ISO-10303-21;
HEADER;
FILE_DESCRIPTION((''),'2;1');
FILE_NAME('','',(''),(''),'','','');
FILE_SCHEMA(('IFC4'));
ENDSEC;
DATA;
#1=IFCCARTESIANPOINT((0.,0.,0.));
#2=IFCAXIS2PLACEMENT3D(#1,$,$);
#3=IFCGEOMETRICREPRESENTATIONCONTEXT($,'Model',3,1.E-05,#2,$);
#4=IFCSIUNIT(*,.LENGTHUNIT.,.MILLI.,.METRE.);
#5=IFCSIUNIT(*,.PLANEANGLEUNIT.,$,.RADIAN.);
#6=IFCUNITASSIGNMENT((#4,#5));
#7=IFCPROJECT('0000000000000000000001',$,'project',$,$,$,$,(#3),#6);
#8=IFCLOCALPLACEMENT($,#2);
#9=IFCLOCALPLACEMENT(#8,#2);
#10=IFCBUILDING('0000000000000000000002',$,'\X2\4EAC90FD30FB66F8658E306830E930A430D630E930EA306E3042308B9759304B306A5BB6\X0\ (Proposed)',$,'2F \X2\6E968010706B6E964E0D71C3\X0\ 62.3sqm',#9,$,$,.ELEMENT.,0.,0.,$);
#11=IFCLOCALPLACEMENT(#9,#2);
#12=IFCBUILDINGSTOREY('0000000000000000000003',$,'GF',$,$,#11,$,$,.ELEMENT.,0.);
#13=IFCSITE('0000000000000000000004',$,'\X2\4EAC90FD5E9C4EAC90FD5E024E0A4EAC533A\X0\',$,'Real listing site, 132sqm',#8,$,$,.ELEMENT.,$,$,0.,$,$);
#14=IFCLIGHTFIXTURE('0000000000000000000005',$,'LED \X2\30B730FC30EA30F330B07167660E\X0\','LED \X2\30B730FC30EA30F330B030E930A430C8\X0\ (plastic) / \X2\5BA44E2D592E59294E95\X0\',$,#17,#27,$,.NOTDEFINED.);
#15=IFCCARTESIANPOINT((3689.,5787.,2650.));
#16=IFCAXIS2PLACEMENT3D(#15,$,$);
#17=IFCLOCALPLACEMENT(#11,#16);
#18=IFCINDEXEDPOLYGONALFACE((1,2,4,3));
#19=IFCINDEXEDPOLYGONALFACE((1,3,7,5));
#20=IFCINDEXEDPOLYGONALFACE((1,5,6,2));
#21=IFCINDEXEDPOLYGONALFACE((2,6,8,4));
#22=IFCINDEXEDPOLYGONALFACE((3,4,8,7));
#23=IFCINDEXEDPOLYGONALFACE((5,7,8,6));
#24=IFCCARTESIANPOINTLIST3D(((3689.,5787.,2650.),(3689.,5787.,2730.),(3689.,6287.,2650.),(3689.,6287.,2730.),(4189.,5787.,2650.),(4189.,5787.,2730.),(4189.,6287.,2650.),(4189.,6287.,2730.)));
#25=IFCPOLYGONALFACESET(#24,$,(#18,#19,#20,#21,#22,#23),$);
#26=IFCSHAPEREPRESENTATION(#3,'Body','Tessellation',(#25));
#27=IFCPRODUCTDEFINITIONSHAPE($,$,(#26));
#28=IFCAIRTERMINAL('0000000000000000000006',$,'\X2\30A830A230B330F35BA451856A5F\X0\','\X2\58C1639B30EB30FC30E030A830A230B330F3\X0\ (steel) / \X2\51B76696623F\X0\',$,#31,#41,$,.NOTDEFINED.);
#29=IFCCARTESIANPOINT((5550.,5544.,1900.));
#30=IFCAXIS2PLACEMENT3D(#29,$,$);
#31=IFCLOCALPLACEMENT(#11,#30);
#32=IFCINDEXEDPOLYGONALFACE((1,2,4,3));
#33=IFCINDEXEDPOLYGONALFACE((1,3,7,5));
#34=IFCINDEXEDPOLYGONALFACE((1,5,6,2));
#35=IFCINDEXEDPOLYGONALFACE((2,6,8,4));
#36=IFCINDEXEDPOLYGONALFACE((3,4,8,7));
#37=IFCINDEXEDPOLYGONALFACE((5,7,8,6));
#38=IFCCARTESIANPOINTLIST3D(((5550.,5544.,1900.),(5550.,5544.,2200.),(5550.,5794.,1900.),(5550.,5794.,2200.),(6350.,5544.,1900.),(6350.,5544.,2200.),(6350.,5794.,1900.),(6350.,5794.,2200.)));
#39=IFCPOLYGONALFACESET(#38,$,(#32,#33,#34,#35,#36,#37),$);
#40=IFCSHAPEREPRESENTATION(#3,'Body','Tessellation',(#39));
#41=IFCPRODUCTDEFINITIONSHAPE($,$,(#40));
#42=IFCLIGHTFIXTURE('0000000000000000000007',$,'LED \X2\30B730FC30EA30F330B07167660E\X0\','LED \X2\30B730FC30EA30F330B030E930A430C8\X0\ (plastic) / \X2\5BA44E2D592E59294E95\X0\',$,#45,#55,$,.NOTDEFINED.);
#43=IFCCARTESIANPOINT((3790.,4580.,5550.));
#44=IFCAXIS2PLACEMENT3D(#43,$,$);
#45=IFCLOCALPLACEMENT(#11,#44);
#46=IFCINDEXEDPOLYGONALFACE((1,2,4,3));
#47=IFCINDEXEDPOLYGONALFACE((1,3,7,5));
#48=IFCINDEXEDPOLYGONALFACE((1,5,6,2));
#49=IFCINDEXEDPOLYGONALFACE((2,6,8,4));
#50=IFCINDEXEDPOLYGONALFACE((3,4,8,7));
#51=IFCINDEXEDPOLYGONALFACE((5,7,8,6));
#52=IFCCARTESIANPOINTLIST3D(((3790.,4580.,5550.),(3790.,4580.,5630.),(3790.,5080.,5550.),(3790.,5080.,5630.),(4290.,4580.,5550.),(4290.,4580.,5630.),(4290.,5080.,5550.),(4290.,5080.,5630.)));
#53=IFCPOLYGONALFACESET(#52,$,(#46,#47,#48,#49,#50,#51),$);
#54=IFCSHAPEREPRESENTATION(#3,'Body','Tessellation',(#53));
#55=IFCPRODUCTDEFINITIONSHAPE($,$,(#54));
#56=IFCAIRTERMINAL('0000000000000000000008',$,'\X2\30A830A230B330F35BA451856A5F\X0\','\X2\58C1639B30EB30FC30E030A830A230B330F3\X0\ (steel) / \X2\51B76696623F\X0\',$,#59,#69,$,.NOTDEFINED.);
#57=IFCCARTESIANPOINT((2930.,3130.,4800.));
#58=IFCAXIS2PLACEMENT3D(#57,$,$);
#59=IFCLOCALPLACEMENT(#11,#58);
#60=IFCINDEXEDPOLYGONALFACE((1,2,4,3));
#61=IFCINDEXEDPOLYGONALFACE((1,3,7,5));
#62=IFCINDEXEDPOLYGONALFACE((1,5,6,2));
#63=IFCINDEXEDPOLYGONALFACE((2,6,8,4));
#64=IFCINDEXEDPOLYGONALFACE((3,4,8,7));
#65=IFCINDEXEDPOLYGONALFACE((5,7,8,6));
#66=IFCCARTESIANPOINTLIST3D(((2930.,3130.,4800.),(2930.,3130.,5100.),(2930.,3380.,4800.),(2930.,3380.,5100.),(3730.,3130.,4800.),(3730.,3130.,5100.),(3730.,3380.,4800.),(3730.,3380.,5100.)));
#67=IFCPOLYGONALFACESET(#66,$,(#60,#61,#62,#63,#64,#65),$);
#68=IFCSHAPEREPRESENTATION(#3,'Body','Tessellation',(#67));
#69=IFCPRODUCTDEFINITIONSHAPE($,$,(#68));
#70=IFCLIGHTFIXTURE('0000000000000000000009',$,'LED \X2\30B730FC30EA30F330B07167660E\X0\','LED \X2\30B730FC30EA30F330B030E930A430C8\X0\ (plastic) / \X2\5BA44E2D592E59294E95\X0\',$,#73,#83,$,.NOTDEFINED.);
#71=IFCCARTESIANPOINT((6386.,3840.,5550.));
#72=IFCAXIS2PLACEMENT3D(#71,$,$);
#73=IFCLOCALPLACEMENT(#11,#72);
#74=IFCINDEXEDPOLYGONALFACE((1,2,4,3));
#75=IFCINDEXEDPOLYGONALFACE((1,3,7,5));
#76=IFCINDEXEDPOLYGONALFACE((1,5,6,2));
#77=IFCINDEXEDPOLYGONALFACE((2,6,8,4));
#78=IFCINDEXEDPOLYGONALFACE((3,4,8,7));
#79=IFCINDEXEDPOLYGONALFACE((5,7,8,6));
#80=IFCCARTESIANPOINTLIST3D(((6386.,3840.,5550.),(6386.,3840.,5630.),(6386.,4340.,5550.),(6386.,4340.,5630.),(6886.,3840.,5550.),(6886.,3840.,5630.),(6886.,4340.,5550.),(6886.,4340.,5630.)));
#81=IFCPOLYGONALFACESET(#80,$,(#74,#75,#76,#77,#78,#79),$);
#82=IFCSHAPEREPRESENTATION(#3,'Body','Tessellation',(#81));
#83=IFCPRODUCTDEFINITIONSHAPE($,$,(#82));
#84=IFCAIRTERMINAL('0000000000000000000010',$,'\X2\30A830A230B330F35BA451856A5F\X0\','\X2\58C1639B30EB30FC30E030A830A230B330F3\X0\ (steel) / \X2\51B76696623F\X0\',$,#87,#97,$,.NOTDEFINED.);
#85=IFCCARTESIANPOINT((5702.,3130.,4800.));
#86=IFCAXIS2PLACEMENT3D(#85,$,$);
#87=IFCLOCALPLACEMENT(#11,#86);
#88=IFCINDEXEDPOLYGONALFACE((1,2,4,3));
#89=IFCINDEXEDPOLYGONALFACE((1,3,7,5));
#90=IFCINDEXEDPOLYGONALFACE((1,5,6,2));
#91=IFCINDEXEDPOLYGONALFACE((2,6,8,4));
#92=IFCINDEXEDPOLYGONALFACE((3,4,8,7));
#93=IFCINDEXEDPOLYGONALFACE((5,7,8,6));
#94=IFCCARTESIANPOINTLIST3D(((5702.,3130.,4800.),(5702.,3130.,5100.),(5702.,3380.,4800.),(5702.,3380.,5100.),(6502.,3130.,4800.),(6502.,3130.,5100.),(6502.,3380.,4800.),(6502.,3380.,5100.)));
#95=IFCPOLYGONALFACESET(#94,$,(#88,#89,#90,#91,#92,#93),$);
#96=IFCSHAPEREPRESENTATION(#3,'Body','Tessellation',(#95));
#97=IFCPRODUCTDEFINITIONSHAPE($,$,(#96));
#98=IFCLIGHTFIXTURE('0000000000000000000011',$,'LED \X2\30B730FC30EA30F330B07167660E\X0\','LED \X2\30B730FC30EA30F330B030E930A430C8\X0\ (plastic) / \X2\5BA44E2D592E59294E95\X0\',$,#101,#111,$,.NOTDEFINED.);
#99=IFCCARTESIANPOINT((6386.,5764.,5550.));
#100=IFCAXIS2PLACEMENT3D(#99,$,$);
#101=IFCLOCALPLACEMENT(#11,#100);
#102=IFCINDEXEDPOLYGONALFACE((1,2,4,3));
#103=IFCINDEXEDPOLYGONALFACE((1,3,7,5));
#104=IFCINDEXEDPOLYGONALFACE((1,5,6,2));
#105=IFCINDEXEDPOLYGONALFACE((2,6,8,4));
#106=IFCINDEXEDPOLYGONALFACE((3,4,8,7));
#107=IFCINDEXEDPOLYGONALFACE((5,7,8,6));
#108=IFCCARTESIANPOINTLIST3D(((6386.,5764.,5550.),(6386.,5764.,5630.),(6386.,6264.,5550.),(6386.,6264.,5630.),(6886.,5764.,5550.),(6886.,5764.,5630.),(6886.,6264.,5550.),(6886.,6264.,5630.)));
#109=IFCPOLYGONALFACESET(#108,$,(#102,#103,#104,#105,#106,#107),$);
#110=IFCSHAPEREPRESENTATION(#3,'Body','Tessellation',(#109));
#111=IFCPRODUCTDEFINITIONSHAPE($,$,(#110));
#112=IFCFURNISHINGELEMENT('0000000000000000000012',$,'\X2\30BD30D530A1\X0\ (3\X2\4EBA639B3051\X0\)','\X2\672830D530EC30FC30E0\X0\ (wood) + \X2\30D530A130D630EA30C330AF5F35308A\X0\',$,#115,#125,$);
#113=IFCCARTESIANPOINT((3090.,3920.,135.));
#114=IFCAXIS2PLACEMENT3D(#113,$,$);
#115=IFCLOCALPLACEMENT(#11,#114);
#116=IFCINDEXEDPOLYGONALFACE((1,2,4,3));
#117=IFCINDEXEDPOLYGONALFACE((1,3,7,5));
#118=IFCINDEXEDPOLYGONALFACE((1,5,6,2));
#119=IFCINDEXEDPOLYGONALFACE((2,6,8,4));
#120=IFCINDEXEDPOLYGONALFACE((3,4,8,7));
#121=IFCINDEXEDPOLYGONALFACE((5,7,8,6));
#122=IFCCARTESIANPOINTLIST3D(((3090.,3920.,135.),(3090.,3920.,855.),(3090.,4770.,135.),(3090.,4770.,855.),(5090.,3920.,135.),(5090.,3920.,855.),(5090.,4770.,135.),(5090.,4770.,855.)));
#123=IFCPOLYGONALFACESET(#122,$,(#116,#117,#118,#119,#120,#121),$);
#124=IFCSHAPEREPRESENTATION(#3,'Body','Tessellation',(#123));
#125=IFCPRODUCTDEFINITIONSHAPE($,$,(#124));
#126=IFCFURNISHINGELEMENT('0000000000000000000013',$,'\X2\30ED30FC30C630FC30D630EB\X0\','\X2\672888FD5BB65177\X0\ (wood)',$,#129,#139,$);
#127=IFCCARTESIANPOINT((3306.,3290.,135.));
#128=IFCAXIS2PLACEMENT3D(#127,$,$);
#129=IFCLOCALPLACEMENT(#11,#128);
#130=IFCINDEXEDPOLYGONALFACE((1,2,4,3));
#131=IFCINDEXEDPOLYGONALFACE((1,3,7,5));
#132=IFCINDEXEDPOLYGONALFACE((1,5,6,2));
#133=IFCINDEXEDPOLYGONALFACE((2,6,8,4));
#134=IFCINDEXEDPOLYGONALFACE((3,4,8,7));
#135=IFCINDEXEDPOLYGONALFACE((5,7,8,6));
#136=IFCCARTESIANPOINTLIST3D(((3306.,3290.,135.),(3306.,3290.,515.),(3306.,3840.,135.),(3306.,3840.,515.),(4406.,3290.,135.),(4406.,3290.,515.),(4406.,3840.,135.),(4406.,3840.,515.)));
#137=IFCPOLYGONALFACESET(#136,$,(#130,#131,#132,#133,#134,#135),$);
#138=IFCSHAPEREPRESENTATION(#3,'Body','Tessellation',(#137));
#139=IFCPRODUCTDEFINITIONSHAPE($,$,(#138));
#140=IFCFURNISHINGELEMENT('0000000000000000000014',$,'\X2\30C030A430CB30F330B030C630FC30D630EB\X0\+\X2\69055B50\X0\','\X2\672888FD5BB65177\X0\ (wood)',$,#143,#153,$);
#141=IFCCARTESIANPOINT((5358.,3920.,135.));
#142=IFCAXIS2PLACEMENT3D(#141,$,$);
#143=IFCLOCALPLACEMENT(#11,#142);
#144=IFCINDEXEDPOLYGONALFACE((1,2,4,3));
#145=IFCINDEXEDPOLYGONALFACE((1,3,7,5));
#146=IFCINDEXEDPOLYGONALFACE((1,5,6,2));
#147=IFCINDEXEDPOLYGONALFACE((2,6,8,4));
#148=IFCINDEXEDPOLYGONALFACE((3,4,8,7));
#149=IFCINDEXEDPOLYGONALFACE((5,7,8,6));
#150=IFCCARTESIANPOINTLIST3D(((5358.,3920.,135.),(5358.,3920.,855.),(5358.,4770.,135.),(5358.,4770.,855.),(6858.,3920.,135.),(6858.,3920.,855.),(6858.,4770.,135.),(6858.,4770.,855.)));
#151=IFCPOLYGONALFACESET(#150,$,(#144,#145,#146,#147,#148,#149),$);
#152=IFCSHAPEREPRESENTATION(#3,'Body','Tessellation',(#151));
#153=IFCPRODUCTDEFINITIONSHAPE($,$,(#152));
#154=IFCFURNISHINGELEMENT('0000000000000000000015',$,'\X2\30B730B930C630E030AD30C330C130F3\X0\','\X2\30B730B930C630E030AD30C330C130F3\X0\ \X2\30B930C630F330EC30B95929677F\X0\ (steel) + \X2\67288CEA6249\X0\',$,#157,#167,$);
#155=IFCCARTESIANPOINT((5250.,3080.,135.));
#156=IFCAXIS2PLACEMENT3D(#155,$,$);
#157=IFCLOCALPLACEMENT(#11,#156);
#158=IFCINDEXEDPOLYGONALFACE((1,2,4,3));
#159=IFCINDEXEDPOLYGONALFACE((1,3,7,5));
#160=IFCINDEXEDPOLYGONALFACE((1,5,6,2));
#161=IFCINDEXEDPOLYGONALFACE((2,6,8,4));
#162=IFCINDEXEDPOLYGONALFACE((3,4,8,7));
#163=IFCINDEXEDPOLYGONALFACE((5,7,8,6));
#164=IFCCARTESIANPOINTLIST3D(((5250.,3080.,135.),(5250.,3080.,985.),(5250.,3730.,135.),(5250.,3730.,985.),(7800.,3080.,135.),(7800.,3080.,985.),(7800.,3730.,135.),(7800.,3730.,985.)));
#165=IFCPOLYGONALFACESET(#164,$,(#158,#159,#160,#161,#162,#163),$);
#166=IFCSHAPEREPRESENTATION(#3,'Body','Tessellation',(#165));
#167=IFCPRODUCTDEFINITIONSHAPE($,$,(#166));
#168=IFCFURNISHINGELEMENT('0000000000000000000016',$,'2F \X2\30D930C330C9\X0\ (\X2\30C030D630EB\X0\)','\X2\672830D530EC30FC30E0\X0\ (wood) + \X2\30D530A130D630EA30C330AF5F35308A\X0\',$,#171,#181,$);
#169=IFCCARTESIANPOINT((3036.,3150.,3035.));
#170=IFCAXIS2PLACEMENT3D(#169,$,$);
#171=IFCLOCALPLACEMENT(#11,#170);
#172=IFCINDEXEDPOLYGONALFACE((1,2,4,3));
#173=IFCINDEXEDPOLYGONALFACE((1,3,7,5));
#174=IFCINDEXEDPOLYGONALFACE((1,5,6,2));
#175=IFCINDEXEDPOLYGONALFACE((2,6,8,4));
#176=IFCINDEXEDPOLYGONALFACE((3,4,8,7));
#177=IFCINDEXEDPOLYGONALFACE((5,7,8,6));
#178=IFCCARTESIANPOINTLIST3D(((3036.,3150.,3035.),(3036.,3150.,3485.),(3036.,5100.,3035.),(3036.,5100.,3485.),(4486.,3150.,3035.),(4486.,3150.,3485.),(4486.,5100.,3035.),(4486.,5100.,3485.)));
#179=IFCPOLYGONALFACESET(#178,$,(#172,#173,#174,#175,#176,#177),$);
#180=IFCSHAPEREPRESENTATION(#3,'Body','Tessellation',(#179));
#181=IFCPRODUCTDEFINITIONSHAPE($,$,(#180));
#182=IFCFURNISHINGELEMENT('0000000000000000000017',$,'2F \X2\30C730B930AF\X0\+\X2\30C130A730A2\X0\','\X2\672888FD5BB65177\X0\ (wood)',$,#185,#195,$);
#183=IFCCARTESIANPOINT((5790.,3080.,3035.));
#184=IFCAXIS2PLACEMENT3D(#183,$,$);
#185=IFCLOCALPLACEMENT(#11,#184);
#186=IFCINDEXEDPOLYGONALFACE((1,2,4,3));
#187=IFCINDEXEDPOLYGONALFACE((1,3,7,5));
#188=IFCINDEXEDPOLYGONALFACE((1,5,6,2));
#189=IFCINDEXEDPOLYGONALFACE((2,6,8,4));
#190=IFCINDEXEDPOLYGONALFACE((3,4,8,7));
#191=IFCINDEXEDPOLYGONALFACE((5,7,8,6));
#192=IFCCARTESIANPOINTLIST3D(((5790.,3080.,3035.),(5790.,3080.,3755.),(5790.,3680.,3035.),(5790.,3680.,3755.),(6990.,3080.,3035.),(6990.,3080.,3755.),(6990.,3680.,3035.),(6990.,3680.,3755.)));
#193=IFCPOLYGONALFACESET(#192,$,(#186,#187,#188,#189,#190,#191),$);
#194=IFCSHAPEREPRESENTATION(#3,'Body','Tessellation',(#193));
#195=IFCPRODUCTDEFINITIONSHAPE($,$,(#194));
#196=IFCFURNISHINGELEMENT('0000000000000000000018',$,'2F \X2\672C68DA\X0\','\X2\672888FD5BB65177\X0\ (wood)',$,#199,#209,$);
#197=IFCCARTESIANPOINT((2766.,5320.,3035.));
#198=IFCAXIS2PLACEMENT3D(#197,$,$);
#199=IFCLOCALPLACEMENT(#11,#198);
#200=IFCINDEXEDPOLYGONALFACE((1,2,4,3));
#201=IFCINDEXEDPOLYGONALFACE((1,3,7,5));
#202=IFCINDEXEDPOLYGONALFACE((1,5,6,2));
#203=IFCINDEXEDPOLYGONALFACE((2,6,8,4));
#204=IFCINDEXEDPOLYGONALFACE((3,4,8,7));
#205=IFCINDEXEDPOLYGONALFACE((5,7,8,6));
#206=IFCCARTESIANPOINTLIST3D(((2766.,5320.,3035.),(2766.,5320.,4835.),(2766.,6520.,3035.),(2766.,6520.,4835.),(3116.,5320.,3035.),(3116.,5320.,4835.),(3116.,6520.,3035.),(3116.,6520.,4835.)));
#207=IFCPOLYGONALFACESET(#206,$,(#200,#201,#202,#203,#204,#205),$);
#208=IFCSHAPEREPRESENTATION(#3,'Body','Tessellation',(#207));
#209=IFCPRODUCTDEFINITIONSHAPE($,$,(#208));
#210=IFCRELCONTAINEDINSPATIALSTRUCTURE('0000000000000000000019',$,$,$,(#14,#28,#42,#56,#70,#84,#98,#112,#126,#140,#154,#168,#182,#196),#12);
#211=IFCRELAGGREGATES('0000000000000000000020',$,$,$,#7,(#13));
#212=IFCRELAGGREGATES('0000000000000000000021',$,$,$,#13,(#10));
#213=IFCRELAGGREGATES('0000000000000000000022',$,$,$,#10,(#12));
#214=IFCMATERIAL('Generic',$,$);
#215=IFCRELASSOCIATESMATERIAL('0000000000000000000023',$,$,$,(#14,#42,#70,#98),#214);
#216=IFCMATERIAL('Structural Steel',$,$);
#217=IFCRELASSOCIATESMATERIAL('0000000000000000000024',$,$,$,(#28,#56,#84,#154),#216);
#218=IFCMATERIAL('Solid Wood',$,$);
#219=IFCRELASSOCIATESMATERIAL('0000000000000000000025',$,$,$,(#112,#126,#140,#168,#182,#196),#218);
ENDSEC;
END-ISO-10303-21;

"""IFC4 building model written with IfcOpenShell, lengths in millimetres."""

from ifc_helpers import new_model, si_unit, frame, frame_2d, origin, place, context, project, spatial, rectangle, extrude, material, element, save


model = new_model("IFC4")

# Units and contexts
model_context = context("Model", 3, precision=1e-05, world=origin())
ifc_project = project(units=[si_unit("LENGTHUNIT", "METRE", prefix="MILLI"), si_unit("PLANEANGLEUNIT", "RADIAN")], contexts=[model_context])

# Site, building, storey
site_placement = place(None, origin())
site = spatial("IfcSite", under=ifc_project, at=site_placement, Name="京都府京都市上京区", ObjectType="Real listing site, 132sqm", CompositionType="ELEMENT", RefElevation=0.0)
building_placement = place(site_placement, origin())
building = spatial("IfcBuilding", under=site, at=building_placement, Name="京都・書斎とライブラリのある静かな家 (Proposed)", ObjectType="2F 準耐火準不燃 62.3sqm", CompositionType="ELEMENT", ElevationOfRefHeight=0.0, ElevationOfTerrain=0.0)
storey_placement = place(building_placement, origin())
storey = spatial("IfcBuildingStorey", under=building, at=storey_placement, Name="GF", CompositionType="ELEMENT", Elevation=0.0)

# Shared definitions
ifc_material_1 = material(Name="Solid Wood")

# Shared definitions
ifc_material_2 = material(Name="Structural Steel")

# Shared definitions
ifc_material_3 = material(Name="Generic")

# Light fixture
light_fixture_1_placement = place(storey_placement, frame((3689.0, 5787.0, 2650.0)))
element("IfcLightFixture", 1, at=light_fixture_1_placement, inside=storey, material=ifc_material_3, Name="LED シーリング照明", Description="LED シーリングライト (plastic) / 室中央天井", PredefinedType="NOTDEFINED", context=model_context, shape_type="SweptSolid", body=[
    extrude(rectangle(XDim=500.0, YDim=500.0, at=frame_2d((250.0, 250.0))), frame((3689.0, 5787.0, 2650.0)), (0.0, 0.0, 1.0), 80.0),
])

# Air terminal
air_terminal_1_placement = place(storey_placement, frame((5550.0, 5544.0, 1900.0)))
element("IfcAirTerminal", 2, at=air_terminal_1_placement, inside=storey, material=ifc_material_2, Name="エアコン室内機", Description="壁掛ルームエアコン (steel) / 冷暖房", PredefinedType="NOTDEFINED", context=model_context, shape_type="SweptSolid", body=[
    extrude(rectangle(XDim=800.0, YDim=250.0, at=frame_2d((400.0, 125.0))), frame((5550.0, 5544.0, 1900.0)), (0.0, 0.0, 1.0), 300.0),
])

# Light fixture
light_fixture_2_placement = place(storey_placement, frame((3790.0, 4580.0, 5550.0)))
element("IfcLightFixture", 3, at=light_fixture_2_placement, inside=storey, material=ifc_material_3, Name="LED シーリング照明", Description="LED シーリングライト (plastic) / 室中央天井", PredefinedType="NOTDEFINED", context=model_context, shape_type="SweptSolid", body=[
    extrude(rectangle(XDim=500.0, YDim=500.0, at=frame_2d((250.0, 250.0))), frame((3790.0, 4580.0, 5550.0)), (0.0, 0.0, 1.0), 80.0),
])

# Air terminal
air_terminal_2_placement = place(storey_placement, frame((2930.0, 3130.0, 4800.0)))
element("IfcAirTerminal", 4, at=air_terminal_2_placement, inside=storey, material=ifc_material_2, Name="エアコン室内機", Description="壁掛ルームエアコン (steel) / 冷暖房", PredefinedType="NOTDEFINED", context=model_context, shape_type="SweptSolid", body=[
    extrude(rectangle(XDim=800.0, YDim=250.0, at=frame_2d((400.0, 125.0))), frame((2930.0, 3130.0, 4800.0)), (0.0, 0.0, 1.0), 300.0),
])

# Light fixture
light_fixture_3_placement = place(storey_placement, frame((6386.0, 3840.0, 5550.0)))
element("IfcLightFixture", 5, at=light_fixture_3_placement, inside=storey, material=ifc_material_3, Name="LED シーリング照明", Description="LED シーリングライト (plastic) / 室中央天井", PredefinedType="NOTDEFINED", context=model_context, shape_type="SweptSolid", body=[
    extrude(rectangle(XDim=500.0, YDim=500.0, at=frame_2d((250.0, 250.0))), frame((6386.0, 3840.0, 5550.0)), (0.0, 0.0, 1.0), 80.0),
])

# Air terminal
air_terminal_3_placement = place(storey_placement, frame((5702.0, 3130.0, 4800.0)))
element("IfcAirTerminal", 6, at=air_terminal_3_placement, inside=storey, material=ifc_material_2, Name="エアコン室内機", Description="壁掛ルームエアコン (steel) / 冷暖房", PredefinedType="NOTDEFINED", context=model_context, shape_type="SweptSolid", body=[
    extrude(rectangle(XDim=800.0, YDim=250.0, at=frame_2d((400.0, 125.0))), frame((5702.0, 3130.0, 4800.0)), (0.0, 0.0, 1.0), 300.0),
])

# Light fixture
light_fixture_4_placement = place(storey_placement, frame((6386.0, 5764.0, 5550.0)))
element("IfcLightFixture", 7, at=light_fixture_4_placement, inside=storey, material=ifc_material_3, Name="LED シーリング照明", Description="LED シーリングライト (plastic) / 室中央天井", PredefinedType="NOTDEFINED", context=model_context, shape_type="SweptSolid", body=[
    extrude(rectangle(XDim=500.0, YDim=500.0, at=frame_2d((250.0, 250.0))), frame((6386.0, 5764.0, 5550.0)), (0.0, 0.0, 1.0), 80.0),
])

# Furnishing elements
furnishing_1_placement = place(storey_placement, frame((3090.0, 3920.0, 135.0)))
element("IfcFurnishingElement", 8, at=furnishing_1_placement, inside=storey, material=ifc_material_1, Name="ソファ (3人掛け)", Description="木フレーム (wood) + ファブリック張り", context=model_context, shape_type="SweptSolid", body=[
    extrude(rectangle(XDim=2000.0, YDim=850.0, at=frame_2d((1000.0, 425.0))), frame((3090.0, 3920.0, 135.0)), (0.0, 0.0, 1.0), 720.0),
])
furnishing_2_placement = place(storey_placement, frame((3306.0, 3290.0, 135.0)))
element("IfcFurnishingElement", 9, at=furnishing_2_placement, inside=storey, material=ifc_material_1, Name="ローテーブル", Description="木製家具 (wood)", context=model_context, shape_type="SweptSolid", body=[
    extrude(rectangle(XDim=1100.0, YDim=550.0, at=frame_2d((550.0, 275.0))), frame((3306.0, 3290.0, 135.0)), (0.0, 0.0, 1.0), 380.0),
])
furnishing_3_placement = place(storey_placement, frame((5358.0, 3920.0, 135.0)))
element("IfcFurnishingElement", 10, at=furnishing_3_placement, inside=storey, material=ifc_material_1, Name="ダイニングテーブル+椅子", Description="木製家具 (wood)", context=model_context, shape_type="SweptSolid", body=[
    extrude(rectangle(XDim=1500.0, YDim=850.0, at=frame_2d((750.0, 425.0))), frame((5358.0, 3920.0, 135.0)), (0.0, 0.0, 1.0), 720.0),
])
furnishing_4_placement = place(storey_placement, frame((5250.0, 3080.0, 135.0)))
element("IfcFurnishingElement", 11, at=furnishing_4_placement, inside=storey, material=ifc_material_2, Name="システムキッチン", Description="システムキッチン ステンレス天板 (steel) + 木質扉", context=model_context, shape_type="SweptSolid", body=[
    extrude(rectangle(XDim=2550.0, YDim=650.0, at=frame_2d((1275.0, 325.0))), frame((5250.0, 3080.0, 135.0)), (0.0, 0.0, 1.0), 850.0),
])
furnishing_5_placement = place(storey_placement, frame((3036.0, 3150.0, 3035.0)))
element("IfcFurnishingElement", 12, at=furnishing_5_placement, inside=storey, material=ifc_material_1, Name="2F ベッド (ダブル)", Description="木フレーム (wood) + ファブリック張り", context=model_context, shape_type="SweptSolid", body=[
    extrude(rectangle(XDim=1450.0, YDim=1950.0, at=frame_2d((725.0, 975.0))), frame((3036.0, 3150.0, 3035.0)), (0.0, 0.0, 1.0), 450.0),
])
furnishing_6_placement = place(storey_placement, frame((5790.0, 3080.0, 3035.0)))
element("IfcFurnishingElement", 13, at=furnishing_6_placement, inside=storey, material=ifc_material_1, Name="2F デスク+チェア", Description="木製家具 (wood)", context=model_context, shape_type="SweptSolid", body=[
    extrude(rectangle(XDim=1200.0, YDim=600.0, at=frame_2d((600.0, 300.0))), frame((5790.0, 3080.0, 3035.0)), (0.0, 0.0, 1.0), 720.0),
])
furnishing_7_placement = place(storey_placement, frame((2766.0, 5320.0, 3035.0)))
element("IfcFurnishingElement", 14, at=furnishing_7_placement, inside=storey, material=ifc_material_1, Name="2F 本棚", Description="木製家具 (wood)", context=model_context, shape_type="SweptSolid", body=[
    extrude(rectangle(XDim=350.0, YDim=1200.0, at=frame_2d((175.0, 600.0))), frame((2766.0, 5320.0, 3035.0)), (0.0, 0.0, 1.0), 1800.0),
])

save(model, "model.ifc")
